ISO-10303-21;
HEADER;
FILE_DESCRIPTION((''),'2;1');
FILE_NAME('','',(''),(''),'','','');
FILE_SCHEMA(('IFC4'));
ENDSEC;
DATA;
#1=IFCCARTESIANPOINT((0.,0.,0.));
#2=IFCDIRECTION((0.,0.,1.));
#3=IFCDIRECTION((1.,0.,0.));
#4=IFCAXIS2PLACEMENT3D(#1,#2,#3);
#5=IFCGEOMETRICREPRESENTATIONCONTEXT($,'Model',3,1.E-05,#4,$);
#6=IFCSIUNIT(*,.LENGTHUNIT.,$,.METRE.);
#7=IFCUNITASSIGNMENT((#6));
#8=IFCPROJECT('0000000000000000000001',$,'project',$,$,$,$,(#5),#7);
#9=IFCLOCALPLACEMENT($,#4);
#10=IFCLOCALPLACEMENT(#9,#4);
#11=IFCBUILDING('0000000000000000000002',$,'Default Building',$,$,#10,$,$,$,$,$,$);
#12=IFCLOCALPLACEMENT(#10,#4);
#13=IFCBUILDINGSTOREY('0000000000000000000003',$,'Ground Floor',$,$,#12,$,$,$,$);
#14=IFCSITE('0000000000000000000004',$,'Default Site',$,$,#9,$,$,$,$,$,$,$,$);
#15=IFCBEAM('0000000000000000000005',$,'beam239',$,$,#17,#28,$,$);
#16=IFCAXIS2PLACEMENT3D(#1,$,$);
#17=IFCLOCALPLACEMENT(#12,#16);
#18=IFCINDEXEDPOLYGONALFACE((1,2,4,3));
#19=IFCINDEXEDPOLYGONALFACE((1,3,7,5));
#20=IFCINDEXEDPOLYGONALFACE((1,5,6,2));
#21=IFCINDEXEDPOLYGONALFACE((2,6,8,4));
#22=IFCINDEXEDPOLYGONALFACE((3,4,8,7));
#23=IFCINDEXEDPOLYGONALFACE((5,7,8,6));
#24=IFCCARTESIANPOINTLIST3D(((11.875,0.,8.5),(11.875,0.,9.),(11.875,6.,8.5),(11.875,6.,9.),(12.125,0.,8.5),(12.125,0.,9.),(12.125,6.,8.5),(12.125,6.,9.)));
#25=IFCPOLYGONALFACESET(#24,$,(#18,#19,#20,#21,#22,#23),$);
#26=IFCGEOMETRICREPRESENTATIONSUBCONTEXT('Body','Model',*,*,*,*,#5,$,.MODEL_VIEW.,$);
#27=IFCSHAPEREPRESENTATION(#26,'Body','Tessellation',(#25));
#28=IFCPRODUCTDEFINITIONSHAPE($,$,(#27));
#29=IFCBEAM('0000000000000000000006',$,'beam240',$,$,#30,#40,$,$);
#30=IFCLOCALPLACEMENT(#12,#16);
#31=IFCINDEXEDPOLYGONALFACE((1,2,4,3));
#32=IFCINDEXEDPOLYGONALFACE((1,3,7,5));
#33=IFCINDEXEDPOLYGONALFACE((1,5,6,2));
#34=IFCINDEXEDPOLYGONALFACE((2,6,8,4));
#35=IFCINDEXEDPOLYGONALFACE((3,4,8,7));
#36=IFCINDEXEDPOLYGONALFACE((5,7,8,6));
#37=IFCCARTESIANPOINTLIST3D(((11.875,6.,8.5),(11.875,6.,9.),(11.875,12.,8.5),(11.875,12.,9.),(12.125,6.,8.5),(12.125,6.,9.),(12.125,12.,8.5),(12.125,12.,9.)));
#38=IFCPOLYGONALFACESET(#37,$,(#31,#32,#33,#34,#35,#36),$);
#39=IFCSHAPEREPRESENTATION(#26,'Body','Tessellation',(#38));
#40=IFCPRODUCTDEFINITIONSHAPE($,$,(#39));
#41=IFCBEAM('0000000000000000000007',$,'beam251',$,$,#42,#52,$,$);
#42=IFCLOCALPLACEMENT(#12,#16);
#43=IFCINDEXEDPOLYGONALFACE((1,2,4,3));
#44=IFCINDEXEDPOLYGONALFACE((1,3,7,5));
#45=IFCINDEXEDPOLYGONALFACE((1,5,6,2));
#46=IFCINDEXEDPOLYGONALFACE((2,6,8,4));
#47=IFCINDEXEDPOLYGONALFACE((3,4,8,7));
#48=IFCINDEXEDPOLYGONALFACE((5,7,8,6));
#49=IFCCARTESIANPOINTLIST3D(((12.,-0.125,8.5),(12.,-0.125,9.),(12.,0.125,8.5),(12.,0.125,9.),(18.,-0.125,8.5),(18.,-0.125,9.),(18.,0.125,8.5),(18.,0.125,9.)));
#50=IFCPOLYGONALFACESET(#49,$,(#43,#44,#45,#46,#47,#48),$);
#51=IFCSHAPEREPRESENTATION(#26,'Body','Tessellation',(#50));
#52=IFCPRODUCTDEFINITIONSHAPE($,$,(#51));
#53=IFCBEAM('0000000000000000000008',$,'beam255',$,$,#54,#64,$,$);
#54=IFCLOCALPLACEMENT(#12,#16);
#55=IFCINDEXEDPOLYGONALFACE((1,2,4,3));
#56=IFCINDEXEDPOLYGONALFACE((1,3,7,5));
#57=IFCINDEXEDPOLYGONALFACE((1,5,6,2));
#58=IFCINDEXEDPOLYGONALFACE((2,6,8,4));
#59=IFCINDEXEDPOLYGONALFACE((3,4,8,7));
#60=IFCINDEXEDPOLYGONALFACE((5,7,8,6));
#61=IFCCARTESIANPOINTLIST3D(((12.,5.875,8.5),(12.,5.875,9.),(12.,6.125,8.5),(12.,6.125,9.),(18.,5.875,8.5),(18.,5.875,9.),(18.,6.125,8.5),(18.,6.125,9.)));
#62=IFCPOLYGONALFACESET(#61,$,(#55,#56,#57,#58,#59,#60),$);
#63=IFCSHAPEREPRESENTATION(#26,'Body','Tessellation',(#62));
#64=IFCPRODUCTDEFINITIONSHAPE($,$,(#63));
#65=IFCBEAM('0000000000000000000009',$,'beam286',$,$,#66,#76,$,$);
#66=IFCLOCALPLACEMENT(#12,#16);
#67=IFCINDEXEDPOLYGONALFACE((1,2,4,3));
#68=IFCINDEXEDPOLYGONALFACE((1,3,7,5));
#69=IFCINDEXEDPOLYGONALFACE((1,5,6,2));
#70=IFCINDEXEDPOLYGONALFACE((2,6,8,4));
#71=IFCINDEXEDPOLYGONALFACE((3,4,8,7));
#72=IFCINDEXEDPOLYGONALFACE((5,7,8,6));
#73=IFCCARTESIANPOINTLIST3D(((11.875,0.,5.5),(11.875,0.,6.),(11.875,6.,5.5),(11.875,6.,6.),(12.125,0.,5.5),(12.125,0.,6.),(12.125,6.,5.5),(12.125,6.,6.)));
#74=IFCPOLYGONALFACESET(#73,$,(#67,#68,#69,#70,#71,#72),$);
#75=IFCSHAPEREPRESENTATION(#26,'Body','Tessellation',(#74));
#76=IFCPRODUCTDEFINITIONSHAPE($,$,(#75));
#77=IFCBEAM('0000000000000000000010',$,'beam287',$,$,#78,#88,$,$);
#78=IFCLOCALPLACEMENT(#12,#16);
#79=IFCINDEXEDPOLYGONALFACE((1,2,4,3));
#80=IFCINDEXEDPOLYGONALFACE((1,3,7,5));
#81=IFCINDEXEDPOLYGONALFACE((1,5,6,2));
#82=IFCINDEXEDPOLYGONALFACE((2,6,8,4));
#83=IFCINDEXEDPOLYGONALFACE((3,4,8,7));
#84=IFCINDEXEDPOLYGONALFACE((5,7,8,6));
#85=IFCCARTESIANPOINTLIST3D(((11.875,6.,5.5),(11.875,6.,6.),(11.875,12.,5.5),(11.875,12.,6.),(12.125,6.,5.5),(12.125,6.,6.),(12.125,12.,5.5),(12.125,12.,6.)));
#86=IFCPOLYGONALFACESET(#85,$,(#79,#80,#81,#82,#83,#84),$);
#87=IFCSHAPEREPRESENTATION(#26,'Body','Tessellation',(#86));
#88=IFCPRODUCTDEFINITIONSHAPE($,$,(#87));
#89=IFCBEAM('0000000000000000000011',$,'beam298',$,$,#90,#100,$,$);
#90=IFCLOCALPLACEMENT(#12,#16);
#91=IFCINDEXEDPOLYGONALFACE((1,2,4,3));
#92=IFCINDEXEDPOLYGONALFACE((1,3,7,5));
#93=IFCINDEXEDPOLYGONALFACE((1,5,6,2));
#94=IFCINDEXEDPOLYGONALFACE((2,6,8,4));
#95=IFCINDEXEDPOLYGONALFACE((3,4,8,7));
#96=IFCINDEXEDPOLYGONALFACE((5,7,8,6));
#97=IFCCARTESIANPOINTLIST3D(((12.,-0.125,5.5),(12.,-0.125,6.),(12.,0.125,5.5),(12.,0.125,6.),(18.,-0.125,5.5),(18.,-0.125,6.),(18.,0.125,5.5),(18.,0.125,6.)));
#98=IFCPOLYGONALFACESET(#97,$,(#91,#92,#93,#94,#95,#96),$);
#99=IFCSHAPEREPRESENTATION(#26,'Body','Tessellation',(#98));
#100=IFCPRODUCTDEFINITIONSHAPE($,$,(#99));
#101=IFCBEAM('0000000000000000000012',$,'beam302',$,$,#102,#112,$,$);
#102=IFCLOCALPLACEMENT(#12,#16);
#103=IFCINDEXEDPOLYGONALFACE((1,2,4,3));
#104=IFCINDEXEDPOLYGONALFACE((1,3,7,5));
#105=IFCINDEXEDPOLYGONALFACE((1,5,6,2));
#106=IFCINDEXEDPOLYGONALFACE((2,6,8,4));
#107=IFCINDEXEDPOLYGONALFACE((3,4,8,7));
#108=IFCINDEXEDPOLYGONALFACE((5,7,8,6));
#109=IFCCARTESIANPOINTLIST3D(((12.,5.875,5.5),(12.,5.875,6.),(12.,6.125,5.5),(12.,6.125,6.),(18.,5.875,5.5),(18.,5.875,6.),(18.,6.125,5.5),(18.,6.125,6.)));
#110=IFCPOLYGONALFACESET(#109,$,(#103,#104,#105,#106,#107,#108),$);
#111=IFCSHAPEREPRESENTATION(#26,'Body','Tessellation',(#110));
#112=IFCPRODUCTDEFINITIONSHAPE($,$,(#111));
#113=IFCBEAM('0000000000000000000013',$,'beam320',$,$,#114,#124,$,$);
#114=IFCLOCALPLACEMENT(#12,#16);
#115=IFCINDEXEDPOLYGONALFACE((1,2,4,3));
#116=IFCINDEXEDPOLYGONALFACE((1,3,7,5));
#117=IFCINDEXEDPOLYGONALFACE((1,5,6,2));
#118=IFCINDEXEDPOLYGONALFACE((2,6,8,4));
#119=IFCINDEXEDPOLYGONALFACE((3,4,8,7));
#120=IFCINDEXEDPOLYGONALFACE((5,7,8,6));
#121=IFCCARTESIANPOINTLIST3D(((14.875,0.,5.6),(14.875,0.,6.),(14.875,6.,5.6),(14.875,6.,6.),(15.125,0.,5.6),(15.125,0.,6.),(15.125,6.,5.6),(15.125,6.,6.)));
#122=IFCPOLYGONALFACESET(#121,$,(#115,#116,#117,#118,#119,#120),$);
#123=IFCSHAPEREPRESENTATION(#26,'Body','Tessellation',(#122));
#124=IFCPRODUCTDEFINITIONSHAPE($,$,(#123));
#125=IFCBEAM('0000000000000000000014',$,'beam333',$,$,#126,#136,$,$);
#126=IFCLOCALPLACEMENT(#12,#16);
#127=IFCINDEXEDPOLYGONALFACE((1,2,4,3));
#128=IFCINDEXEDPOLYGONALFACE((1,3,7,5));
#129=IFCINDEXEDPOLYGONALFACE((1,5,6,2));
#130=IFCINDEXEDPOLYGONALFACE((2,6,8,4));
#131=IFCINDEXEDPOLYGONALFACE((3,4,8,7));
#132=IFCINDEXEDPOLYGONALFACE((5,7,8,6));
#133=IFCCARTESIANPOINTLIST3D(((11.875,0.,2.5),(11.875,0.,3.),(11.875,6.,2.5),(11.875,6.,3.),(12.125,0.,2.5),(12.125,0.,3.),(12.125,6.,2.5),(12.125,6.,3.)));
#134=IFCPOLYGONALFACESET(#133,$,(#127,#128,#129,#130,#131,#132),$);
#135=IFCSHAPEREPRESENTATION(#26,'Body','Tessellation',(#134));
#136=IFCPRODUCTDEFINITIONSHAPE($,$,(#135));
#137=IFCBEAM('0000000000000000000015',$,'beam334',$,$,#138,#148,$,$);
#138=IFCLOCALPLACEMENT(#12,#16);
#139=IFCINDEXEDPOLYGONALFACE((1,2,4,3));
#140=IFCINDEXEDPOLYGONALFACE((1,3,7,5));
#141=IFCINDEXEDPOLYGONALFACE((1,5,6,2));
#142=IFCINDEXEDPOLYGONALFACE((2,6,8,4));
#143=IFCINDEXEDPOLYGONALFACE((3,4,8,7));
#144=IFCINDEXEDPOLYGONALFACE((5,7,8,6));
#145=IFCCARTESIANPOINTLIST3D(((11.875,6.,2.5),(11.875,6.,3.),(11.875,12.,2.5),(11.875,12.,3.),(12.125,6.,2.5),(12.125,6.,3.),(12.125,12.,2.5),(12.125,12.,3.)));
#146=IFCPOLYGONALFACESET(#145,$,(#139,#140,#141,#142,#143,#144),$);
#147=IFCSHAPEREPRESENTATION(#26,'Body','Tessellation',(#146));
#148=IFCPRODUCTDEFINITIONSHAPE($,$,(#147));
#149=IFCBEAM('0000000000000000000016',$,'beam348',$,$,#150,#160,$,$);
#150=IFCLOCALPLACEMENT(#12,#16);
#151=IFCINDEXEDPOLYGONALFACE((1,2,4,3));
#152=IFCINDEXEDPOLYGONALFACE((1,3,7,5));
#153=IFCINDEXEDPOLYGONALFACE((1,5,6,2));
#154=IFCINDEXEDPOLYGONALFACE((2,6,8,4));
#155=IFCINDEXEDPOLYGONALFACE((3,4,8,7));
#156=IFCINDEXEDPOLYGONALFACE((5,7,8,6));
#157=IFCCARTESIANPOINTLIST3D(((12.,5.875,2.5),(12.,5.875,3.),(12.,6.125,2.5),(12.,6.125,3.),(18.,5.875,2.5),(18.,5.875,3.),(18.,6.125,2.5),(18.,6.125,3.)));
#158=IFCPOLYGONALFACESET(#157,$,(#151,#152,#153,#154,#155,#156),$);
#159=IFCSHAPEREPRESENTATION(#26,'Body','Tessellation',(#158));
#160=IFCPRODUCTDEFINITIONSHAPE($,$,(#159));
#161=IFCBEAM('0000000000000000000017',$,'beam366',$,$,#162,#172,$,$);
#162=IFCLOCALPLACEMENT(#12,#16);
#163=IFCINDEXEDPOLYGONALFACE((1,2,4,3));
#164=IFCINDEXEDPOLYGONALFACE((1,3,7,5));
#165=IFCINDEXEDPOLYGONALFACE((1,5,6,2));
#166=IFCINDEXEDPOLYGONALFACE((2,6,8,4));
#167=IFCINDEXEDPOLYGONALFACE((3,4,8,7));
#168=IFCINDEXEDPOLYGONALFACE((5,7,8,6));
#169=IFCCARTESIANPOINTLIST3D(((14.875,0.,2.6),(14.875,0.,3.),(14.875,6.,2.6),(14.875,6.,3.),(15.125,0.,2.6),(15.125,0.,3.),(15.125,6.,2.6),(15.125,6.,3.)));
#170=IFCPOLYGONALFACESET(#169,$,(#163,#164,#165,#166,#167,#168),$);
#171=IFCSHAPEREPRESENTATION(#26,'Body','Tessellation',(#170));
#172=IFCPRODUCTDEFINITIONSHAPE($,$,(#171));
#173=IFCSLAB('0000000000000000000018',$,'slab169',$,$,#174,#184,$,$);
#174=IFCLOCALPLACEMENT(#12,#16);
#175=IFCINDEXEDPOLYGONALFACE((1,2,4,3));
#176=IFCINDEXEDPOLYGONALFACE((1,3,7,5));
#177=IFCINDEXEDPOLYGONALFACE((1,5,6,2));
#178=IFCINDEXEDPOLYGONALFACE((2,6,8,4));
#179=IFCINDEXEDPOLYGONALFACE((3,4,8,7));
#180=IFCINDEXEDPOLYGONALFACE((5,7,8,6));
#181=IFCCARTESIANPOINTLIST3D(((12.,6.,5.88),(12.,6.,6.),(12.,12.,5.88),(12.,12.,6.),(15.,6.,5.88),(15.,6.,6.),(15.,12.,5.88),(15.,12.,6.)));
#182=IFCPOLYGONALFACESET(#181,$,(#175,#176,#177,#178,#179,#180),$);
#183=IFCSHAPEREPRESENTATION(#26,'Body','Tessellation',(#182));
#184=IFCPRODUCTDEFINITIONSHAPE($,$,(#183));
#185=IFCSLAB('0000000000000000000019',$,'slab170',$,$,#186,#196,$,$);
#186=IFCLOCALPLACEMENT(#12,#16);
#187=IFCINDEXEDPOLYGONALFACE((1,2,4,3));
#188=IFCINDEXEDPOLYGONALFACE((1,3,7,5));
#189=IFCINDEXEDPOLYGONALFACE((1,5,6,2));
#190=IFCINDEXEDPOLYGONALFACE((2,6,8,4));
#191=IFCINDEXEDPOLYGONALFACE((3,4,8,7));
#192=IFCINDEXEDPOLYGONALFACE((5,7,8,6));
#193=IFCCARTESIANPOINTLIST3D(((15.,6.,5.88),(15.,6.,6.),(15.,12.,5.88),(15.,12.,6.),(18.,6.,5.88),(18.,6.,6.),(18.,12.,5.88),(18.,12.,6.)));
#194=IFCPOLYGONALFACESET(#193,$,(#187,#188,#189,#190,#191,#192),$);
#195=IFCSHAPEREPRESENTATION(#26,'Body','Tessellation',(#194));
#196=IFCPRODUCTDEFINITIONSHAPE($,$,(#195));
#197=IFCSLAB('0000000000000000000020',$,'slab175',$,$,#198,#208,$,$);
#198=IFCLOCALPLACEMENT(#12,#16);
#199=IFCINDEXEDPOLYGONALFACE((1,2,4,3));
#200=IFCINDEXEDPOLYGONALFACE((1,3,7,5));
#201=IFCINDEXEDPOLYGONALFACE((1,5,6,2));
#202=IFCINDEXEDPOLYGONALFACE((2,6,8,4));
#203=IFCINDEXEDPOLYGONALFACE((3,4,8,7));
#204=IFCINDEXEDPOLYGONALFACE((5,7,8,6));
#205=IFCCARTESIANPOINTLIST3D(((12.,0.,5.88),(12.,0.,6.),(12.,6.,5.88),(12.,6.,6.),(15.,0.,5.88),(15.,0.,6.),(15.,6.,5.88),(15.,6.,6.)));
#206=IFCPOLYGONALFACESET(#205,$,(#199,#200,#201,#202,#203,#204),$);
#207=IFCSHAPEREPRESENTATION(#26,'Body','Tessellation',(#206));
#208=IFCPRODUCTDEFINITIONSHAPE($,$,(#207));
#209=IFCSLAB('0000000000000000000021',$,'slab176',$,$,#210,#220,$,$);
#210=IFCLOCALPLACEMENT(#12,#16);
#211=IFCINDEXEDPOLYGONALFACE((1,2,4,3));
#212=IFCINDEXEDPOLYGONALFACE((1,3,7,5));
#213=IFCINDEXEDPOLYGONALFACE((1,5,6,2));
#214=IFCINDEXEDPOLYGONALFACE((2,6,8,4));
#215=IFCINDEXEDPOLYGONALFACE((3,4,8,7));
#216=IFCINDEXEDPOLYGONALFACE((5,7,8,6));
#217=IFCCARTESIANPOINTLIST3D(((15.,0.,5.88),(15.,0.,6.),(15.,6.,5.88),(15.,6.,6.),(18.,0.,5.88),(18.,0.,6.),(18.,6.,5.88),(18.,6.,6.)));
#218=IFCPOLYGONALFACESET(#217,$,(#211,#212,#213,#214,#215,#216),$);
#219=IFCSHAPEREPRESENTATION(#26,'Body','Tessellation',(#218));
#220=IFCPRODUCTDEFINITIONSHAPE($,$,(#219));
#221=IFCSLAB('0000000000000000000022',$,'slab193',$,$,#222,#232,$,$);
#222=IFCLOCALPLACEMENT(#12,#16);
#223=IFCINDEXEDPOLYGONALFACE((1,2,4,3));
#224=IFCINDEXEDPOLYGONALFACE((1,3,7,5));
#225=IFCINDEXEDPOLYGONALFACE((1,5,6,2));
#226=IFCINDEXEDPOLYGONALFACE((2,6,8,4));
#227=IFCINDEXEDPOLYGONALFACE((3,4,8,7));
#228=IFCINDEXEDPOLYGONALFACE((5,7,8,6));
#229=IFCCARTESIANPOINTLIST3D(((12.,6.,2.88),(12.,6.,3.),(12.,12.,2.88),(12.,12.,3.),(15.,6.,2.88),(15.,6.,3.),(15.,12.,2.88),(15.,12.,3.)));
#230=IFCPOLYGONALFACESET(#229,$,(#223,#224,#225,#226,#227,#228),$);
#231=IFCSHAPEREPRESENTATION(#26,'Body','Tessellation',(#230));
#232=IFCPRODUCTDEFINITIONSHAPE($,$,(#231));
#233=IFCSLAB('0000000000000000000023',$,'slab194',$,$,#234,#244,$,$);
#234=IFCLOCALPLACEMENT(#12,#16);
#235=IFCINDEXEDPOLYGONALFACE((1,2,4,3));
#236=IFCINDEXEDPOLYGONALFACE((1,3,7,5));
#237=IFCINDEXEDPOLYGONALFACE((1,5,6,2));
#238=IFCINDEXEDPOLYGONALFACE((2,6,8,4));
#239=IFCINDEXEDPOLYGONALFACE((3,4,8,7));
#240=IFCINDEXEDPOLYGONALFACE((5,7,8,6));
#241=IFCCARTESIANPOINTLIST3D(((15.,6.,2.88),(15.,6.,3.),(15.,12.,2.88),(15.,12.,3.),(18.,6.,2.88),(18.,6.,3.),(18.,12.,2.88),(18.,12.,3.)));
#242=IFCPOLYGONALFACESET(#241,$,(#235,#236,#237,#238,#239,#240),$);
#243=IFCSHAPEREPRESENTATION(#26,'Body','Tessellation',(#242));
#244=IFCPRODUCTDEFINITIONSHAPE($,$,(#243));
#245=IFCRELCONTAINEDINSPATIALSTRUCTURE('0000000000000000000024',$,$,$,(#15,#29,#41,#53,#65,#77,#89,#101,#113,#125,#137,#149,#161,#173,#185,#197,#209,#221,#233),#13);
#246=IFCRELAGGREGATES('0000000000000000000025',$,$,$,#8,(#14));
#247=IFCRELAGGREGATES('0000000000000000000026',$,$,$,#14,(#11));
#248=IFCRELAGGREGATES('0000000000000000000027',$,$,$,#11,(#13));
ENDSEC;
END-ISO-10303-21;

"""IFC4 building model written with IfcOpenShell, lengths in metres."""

from ifc_helpers import new_model, si_unit, frame, origin_with_axes, place, context, subcontext, project, spatial, indexed_curve, outline, extrude, element, save


model = new_model("IFC4")

# Units and contexts
model_context = context("Model", 3, precision=1e-05, world=origin_with_axes())
body_context = subcontext(model_context, "Body", "Model", "MODEL_VIEW")
ifc_project = project(units=[si_unit("LENGTHUNIT", "METRE")], contexts=[model_context])

# Site, building, storey
site_placement = place(None, origin_with_axes())
site = spatial("IfcSite", under=ifc_project, at=site_placement, Name="Default Site")
building_placement = place(site_placement, origin_with_axes())
building = spatial("IfcBuilding", under=site, at=building_placement, Name="Default Building")
storey_placement = place(building_placement, origin_with_axes())
storey = spatial("IfcBuildingStorey", under=building, at=storey_placement, Name="Ground Floor")

# Beams
for number, where, z_axis, x_axis, name in (
    (1, (12.125, 0.0, 8.5), (0.0, 0.0, 1.0), (0.0, 1.0, 0.0), "beam239"),
    (2, (12.125, 6.0, 8.5), (0.0, 0.0, 1.0), (0.0, 1.0, 0.0), "beam240"),
    (3, (12.0, -0.125, 8.5), (0.0, 0.0, 1.0), (1.0, 0.0, 0.0), "beam251"),
    (4, (12.0, 5.875, 8.5), (0.0, 0.0, 1.0), (1.0, 0.0, 0.0), "beam255"),
    (5, (12.125, 0.0, 5.5), (0.0, 0.0, 1.0), (0.0, 1.0, 0.0), "beam286"),
    (6, (12.125, 6.0, 5.5), (0.0, 0.0, 1.0), (0.0, 1.0, 0.0), "beam287"),
    (7, (12.0, -0.125, 5.5), (0.0, 0.0, 1.0), (1.0, 0.0, 0.0), "beam298"),
    (8, (12.0, 5.875, 5.5), (0.0, 0.0, 1.0), (1.0, 0.0, 0.0), "beam302"),
):
    element("IfcBeam", number, at=place(storey_placement, frame(where, z_axis=z_axis, x_axis=x_axis)), inside=storey, Name=name, context=body_context, shape_type="SweptSolid", body=[
        extrude(outline(indexed_curve([(0.0, 0.0), (0.0, 0.25), (6.0, 0.25), (6.0, 0.0), (0.0, 0.0)], self_intersect=False)), origin_with_axes(), (0.0, 0.0, 1.0), 0.5),
    ])
beam_1_placement = place(storey_placement, frame((14.875, 6.0, 5.6), z_axis=(0.0, 0.0, 1.0), x_axis=(0.0, -1.0, 0.0)))
element("IfcBeam", 9, at=beam_1_placement, inside=storey, Name="beam320", context=body_context, shape_type="SweptSolid", body=[
    extrude(outline(indexed_curve([(0.0, 0.0), (0.0, 0.25), (6.0, 0.25), (6.0, 0.0), (0.0, 0.0)], self_intersect=False)), origin_with_axes(), (0.0, 0.0, 1.0), 0.4),
])
for number, where, z_axis, x_axis, name in (
    (10, (12.125, 0.0, 2.5), (0.0, 0.0, 1.0), (0.0, 1.0, 0.0), "beam333"),
    (11, (12.125, 6.0, 2.5), (0.0, 0.0, 1.0), (0.0, 1.0, 0.0), "beam334"),
    (12, (12.0, 5.875, 2.5), (0.0, 0.0, 1.0), (1.0, 0.0, 0.0), "beam348"),
):
    element("IfcBeam", number, at=place(storey_placement, frame(where, z_axis=z_axis, x_axis=x_axis)), inside=storey, Name=name, context=body_context, shape_type="SweptSolid", body=[
        extrude(outline(indexed_curve([(0.0, 0.0), (0.0, 0.25), (6.0, 0.25), (6.0, 0.0), (0.0, 0.0)], self_intersect=False)), origin_with_axes(), (0.0, 0.0, 1.0), 0.5),
    ])
beam_2_placement = place(storey_placement, frame((14.875, 6.0, 2.6), z_axis=(0.0, 0.0, 1.0), x_axis=(0.0, -1.0, 0.0)))
element("IfcBeam", 13, at=beam_2_placement, inside=storey, Name="beam366", context=body_context, shape_type="SweptSolid", body=[
    extrude(outline(indexed_curve([(0.0, 0.0), (0.0, 0.25), (6.0, 0.25), (6.0, 0.0), (0.0, 0.0)], self_intersect=False)), origin_with_axes(), (0.0, 0.0, 1.0), 0.4),
])

# Slabs
for number, where, z_axis, x_axis, name in (
    (14, (12.0, 6.0, 5.88), (0.0, 0.0, 1.0), (1.0, 0.0, 0.0), "slab169"),
    (15, (15.0, 6.0, 5.88), (0.0, 0.0, 1.0), (1.0, 0.0, 0.0), "slab170"),
    (16, (12.0, 0.0, 5.88), (0.0, 0.0, 1.0), (1.0, 0.0, 0.0), "slab175"),
    (17, (15.0, 0.0, 5.88), (0.0, 0.0, 1.0), (1.0, 0.0, 0.0), "slab176"),
    (18, (12.0, 6.0, 2.88), (0.0, 0.0, 1.0), (1.0, 0.0, 0.0), "slab193"),
    (19, (15.0, 6.0, 2.88), (0.0, 0.0, 1.0), (1.0, 0.0, 0.0), "slab194"),
):
    element("IfcSlab", number, at=place(storey_placement, frame(where, z_axis=z_axis, x_axis=x_axis)), inside=storey, Name=name, context=body_context, shape_type="SweptSolid", body=[
        extrude(outline(indexed_curve([(0.0, 0.0), (0.0, 6.0), (3.0, 6.0), (3.0, 0.0), (0.0, 0.0)], self_intersect=False)), origin_with_axes(), (0.0, 0.0, 1.0), 0.12),
    ])

save(model, "model.ifc")
